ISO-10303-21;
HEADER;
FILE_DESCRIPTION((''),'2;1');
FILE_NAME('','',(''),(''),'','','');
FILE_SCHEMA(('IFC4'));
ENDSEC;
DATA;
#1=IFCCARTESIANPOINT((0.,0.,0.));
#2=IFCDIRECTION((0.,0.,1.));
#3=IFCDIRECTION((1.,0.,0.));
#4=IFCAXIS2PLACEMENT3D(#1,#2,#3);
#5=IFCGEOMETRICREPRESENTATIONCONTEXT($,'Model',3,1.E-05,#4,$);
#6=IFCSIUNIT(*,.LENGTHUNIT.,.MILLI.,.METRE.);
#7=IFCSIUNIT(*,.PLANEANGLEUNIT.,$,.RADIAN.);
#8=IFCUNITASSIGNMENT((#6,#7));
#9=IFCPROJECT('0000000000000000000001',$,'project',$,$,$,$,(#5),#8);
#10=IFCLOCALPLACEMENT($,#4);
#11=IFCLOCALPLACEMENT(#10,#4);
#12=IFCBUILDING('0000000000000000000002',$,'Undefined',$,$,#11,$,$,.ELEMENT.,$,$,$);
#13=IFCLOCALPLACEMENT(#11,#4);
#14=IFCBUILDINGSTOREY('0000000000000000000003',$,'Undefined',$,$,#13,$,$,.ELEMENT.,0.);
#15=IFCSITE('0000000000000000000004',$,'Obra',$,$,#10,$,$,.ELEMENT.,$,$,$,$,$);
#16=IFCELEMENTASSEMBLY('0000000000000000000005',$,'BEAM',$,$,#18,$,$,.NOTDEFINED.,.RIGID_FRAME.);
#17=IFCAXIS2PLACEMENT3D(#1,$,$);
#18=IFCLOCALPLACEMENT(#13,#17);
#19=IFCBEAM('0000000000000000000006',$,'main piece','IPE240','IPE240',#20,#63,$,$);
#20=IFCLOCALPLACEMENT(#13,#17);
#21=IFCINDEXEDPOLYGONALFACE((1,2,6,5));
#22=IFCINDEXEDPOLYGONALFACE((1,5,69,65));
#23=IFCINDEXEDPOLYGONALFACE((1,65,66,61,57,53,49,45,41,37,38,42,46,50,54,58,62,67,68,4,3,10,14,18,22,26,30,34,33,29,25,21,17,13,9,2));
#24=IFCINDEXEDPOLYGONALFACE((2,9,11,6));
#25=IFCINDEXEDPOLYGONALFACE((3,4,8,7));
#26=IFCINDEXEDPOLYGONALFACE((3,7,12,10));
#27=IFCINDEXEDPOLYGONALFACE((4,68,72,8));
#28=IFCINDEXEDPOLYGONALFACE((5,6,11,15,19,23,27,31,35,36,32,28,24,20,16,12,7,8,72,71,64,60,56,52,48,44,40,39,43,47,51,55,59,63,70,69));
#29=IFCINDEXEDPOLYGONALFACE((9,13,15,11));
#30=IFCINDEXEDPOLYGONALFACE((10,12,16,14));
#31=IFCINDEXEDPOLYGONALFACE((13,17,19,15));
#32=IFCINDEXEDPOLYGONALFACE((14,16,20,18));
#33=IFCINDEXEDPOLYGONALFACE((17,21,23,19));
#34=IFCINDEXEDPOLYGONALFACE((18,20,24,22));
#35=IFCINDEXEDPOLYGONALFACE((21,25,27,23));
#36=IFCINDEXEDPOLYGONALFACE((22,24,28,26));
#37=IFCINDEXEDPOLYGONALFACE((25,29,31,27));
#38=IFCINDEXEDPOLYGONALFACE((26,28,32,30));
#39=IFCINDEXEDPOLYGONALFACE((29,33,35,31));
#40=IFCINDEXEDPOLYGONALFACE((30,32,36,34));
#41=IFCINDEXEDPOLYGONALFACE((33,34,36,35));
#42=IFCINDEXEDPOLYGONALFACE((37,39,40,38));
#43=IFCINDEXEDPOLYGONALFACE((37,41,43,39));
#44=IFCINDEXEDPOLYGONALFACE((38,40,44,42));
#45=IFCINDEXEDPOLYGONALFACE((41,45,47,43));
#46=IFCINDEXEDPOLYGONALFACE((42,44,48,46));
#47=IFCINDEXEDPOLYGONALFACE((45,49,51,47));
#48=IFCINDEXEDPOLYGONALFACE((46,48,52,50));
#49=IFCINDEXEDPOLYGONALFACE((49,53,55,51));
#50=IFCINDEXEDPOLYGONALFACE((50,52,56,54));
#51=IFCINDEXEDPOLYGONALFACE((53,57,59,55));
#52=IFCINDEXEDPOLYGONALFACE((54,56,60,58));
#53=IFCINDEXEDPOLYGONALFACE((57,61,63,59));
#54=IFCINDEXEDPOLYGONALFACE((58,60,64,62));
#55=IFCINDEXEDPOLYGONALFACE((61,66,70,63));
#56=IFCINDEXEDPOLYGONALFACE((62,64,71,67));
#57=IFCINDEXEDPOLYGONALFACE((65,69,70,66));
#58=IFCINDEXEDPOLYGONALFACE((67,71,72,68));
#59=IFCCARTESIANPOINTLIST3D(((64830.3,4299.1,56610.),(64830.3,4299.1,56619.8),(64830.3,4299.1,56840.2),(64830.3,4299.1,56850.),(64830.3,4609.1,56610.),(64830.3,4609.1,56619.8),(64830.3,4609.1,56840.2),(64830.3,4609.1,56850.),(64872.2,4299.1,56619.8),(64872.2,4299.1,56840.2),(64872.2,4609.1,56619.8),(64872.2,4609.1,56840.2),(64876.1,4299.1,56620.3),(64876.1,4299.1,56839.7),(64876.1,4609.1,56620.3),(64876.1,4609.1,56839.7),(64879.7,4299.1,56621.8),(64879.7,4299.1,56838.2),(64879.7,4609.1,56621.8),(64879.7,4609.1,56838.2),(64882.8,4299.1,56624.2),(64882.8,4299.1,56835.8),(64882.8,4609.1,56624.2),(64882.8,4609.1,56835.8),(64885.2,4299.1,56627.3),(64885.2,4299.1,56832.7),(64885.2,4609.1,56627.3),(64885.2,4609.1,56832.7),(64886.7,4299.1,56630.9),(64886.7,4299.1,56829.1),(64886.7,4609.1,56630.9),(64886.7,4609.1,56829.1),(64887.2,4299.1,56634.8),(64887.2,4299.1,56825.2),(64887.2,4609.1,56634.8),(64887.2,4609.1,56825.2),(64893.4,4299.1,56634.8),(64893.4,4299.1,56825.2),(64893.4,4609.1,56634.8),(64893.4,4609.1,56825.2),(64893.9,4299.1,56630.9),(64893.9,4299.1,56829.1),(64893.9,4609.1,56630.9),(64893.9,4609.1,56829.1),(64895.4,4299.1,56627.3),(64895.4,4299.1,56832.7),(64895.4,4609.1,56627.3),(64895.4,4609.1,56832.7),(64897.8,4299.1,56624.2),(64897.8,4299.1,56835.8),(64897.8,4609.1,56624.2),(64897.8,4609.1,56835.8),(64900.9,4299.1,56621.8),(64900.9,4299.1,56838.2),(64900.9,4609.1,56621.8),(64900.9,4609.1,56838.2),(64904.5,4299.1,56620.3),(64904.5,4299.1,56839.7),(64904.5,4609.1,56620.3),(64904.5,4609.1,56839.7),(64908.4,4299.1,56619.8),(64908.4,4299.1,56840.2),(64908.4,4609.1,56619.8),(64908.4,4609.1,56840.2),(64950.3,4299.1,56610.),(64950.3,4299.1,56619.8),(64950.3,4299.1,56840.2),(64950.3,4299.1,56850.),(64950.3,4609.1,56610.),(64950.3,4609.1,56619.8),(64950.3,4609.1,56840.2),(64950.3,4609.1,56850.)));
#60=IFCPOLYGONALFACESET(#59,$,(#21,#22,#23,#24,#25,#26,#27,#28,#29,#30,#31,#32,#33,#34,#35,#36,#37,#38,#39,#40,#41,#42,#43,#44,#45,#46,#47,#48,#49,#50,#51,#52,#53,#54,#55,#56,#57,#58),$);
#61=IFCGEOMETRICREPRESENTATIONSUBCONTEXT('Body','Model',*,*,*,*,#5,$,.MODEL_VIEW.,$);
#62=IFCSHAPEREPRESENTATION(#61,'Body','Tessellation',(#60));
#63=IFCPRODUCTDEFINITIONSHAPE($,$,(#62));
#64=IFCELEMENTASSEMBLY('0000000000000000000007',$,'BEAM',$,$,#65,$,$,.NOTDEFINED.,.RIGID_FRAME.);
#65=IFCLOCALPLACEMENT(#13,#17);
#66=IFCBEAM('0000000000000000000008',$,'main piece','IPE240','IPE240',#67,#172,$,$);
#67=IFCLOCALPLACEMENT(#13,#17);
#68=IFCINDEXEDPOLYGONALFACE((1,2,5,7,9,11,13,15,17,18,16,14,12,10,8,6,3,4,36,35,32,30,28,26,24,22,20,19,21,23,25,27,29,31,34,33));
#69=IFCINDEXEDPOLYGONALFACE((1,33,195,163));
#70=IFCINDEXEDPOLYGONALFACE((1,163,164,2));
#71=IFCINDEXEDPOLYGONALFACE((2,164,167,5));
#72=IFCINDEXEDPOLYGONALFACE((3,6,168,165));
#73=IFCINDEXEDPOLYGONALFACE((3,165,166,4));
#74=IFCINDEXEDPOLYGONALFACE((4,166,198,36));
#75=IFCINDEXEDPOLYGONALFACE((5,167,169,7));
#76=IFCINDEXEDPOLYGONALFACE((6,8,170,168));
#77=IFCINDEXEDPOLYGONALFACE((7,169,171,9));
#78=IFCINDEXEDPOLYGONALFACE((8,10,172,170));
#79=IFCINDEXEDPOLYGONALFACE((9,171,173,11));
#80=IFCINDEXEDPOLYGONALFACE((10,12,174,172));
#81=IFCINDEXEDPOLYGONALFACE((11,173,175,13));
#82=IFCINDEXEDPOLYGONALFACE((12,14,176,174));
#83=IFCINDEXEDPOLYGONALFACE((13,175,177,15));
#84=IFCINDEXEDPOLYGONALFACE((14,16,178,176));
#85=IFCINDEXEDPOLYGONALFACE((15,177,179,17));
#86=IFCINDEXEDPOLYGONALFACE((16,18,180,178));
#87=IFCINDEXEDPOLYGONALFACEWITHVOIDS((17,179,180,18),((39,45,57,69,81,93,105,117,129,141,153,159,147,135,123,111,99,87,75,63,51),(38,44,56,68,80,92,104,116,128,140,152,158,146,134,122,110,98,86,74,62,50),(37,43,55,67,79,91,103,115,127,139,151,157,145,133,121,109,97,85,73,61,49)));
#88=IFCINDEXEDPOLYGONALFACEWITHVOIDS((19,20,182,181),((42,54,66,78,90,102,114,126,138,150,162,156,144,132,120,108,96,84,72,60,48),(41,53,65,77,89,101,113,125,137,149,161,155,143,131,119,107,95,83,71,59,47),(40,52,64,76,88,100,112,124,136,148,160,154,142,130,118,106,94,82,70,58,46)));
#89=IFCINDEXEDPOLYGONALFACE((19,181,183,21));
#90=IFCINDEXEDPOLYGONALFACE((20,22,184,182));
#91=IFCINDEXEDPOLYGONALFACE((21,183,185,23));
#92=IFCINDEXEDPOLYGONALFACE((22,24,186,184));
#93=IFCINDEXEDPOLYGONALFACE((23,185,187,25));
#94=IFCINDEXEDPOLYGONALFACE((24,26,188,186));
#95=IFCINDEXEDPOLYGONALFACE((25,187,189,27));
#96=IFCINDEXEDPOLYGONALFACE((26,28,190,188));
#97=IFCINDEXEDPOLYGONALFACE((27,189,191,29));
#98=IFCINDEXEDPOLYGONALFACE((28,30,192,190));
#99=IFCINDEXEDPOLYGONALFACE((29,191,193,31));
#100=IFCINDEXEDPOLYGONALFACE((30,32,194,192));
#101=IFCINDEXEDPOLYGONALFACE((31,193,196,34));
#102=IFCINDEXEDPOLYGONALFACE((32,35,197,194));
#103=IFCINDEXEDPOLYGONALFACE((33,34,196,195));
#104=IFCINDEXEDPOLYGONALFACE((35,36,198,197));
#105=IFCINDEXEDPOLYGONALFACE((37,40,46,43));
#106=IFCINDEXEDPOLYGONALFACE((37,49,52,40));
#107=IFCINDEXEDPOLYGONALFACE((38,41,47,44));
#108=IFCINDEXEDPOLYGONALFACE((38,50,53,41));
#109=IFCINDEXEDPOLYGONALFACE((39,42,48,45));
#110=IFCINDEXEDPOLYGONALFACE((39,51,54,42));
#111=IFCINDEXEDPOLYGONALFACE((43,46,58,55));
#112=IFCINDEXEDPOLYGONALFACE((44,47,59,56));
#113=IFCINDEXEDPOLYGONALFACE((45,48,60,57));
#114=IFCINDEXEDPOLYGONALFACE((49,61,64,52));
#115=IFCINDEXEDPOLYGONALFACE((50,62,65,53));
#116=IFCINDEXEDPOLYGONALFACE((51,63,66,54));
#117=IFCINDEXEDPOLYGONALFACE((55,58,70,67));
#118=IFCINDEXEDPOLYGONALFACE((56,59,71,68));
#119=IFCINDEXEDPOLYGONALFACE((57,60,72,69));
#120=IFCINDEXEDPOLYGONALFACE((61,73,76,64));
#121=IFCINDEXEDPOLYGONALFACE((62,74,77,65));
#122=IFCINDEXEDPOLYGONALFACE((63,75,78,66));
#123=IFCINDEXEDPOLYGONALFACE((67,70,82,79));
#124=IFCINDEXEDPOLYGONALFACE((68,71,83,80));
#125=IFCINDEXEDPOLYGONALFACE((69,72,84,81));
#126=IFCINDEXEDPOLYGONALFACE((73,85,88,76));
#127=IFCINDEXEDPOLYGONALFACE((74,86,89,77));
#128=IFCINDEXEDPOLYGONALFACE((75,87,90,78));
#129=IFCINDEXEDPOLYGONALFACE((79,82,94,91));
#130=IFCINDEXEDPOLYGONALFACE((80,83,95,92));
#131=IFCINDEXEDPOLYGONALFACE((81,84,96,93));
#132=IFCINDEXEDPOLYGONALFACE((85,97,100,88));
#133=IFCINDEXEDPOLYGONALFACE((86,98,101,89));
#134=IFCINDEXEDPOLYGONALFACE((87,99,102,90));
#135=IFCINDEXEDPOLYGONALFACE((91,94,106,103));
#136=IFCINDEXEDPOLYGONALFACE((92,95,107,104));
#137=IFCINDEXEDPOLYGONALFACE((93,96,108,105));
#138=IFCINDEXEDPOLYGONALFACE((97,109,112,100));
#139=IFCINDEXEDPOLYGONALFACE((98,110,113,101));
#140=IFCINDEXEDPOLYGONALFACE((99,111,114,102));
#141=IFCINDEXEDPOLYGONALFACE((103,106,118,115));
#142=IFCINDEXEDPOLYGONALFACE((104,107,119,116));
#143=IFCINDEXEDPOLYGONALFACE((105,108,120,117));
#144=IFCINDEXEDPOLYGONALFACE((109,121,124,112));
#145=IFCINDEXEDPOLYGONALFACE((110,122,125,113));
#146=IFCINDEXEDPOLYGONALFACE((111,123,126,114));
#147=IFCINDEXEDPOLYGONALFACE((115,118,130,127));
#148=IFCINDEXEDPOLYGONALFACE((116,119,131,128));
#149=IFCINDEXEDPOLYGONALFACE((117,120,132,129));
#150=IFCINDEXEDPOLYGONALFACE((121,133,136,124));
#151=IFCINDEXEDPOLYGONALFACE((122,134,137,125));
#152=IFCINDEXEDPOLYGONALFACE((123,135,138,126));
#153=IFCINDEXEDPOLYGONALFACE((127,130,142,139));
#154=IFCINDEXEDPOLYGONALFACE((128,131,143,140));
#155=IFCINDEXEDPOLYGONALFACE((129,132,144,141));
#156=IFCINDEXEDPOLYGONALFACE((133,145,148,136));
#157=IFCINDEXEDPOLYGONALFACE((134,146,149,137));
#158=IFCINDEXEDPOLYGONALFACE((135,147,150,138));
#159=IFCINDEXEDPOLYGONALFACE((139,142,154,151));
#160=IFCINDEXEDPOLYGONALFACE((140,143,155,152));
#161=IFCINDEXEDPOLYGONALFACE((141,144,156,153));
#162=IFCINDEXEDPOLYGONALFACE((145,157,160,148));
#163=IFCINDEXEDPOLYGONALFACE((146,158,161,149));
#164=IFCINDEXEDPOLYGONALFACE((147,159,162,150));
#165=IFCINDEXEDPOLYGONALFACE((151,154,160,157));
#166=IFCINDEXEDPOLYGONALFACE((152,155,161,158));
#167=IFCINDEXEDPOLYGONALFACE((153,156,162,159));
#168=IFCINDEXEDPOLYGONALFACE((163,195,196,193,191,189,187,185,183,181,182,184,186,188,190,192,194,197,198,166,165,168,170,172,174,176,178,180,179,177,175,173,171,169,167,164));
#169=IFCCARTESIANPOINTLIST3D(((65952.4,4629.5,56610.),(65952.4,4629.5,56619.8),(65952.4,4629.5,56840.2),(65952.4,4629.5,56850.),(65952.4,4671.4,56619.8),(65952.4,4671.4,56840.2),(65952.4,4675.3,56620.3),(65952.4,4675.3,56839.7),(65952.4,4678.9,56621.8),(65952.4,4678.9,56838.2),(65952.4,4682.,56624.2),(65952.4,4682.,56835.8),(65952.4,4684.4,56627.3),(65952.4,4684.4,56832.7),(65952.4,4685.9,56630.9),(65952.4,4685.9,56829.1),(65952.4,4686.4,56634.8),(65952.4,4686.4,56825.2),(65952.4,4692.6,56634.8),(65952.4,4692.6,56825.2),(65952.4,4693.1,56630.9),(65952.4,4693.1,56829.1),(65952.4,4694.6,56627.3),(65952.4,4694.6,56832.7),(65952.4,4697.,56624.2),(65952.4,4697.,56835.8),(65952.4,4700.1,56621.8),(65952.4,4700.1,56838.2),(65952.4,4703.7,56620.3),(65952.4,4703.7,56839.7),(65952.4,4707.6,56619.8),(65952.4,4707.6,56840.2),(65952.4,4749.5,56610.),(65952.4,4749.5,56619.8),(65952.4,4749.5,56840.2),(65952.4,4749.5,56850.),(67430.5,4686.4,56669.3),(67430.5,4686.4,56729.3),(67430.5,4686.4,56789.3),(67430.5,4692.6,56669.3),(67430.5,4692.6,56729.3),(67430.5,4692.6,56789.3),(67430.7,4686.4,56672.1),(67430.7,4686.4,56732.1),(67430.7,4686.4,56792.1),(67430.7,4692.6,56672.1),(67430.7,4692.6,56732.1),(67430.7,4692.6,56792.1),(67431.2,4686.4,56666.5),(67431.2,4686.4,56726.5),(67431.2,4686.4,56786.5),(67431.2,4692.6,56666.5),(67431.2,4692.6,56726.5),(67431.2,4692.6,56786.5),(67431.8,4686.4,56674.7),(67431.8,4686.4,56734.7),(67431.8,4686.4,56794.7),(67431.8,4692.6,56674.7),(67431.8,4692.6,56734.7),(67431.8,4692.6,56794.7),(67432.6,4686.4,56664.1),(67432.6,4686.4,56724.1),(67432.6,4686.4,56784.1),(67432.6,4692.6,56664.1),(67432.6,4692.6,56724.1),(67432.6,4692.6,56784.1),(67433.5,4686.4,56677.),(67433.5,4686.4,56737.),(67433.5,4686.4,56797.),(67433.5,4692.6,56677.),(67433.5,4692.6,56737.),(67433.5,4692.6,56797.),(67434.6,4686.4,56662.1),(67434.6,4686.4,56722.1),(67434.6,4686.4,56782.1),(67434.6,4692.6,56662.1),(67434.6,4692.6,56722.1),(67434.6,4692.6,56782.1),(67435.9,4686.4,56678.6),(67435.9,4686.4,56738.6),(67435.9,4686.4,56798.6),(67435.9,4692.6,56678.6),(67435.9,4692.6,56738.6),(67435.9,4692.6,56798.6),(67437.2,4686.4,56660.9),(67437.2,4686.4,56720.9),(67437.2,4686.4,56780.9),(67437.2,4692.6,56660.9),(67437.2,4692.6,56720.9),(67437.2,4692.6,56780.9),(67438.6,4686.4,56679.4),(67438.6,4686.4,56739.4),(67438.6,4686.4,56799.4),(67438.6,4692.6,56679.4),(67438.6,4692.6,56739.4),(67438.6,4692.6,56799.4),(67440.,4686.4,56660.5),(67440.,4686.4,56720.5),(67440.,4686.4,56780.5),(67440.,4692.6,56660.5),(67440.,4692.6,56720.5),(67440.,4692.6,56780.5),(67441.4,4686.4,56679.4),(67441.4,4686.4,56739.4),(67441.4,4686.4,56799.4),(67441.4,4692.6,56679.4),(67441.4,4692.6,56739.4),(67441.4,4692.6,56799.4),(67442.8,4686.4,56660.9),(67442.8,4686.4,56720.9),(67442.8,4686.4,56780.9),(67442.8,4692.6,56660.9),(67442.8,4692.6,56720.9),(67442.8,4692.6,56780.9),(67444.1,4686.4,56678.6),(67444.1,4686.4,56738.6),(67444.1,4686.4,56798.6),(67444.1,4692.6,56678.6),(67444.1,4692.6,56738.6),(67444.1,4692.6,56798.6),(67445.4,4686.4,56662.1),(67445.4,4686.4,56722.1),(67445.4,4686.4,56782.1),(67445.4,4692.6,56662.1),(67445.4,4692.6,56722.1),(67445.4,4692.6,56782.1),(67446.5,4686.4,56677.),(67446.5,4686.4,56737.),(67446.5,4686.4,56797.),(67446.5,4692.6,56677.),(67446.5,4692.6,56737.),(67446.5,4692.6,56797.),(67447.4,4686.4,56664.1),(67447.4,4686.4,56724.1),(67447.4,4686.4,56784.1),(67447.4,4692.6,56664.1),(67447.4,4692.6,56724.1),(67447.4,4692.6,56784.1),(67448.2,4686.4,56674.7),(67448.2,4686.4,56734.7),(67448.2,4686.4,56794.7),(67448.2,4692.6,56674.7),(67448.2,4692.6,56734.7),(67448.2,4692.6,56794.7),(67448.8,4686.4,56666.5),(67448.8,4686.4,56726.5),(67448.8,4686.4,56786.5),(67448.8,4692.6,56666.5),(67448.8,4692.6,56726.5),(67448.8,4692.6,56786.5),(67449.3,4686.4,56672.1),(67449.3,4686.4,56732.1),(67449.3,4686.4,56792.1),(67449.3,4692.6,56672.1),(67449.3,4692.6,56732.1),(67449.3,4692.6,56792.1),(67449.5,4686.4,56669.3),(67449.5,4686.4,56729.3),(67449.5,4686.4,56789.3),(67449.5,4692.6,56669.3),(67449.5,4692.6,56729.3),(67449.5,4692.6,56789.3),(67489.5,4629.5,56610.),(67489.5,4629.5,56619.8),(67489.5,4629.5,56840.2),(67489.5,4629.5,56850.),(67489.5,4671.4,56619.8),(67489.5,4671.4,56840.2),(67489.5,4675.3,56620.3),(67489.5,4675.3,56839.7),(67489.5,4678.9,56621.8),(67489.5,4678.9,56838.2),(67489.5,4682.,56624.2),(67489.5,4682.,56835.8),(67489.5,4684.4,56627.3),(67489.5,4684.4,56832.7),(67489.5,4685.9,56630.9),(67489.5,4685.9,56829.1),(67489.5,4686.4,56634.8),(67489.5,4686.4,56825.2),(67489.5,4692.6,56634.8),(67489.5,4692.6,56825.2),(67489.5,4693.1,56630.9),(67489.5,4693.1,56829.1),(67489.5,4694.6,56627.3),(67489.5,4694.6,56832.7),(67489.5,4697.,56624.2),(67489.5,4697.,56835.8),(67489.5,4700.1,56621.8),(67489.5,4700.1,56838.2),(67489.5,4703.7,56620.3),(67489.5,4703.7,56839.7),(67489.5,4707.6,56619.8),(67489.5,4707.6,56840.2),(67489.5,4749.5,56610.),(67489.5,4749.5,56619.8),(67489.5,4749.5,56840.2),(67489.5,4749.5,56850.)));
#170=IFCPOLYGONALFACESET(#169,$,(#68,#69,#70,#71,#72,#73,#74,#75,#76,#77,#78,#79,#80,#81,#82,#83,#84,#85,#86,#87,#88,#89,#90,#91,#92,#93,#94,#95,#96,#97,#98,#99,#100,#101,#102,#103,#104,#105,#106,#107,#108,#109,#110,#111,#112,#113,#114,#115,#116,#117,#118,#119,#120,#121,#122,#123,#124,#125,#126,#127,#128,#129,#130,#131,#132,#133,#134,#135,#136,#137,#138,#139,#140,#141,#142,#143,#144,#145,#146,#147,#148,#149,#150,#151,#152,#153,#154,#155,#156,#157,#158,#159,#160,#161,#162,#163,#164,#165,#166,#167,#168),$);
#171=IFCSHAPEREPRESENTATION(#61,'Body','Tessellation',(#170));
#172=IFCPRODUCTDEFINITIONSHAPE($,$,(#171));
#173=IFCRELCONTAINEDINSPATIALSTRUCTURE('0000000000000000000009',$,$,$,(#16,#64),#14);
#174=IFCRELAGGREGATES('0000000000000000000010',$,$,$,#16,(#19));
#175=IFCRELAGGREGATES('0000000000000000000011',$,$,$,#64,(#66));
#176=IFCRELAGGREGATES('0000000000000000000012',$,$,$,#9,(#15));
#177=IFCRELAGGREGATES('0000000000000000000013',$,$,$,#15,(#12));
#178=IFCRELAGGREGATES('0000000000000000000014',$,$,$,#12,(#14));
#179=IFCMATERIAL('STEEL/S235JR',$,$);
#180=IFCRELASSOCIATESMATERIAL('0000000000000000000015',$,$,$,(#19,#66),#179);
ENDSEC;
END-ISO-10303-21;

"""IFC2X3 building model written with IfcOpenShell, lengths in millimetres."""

from ifc_helpers import new_model, si_unit, frame, origin_with_axes, origin_2d_with_axis, place, context, subcontext, project, spatial, circle, i_section, extrude, clip, halfspace, source, transform, mapped, material, element, aggregate, save


model = new_model("IFC2X3")

# Units and contexts
model_context = context("Model", 3, precision=1e-05, world=origin_with_axes())
body_context = subcontext(model_context, "Body", "Model", "MODEL_VIEW")
ifc_project = project(units=[si_unit("LENGTHUNIT", "METRE", prefix="MILLI"), si_unit("PLANEANGLEUNIT", "RADIAN")], contexts=[model_context])

# Site, building, storey
site_placement = place(None, origin_with_axes())
site = spatial("IfcSite", under=ifc_project, at=site_placement, Name="Obra", CompositionType="ELEMENT")
building_placement = place(site_placement, origin_with_axes())
building = spatial("IfcBuilding", under=site, at=building_placement, Name="Undefined", CompositionType="ELEMENT")
storey_placement = place(building_placement, origin_with_axes())
storey = spatial("IfcBuildingStorey", under=building, at=storey_placement, Name="Undefined", CompositionType="ELEMENT", Elevation=0.0)

# Shared definitions
ifc_material_1 = material(Name="STEEL/S235JR")

# Element assembly, beam
assembly_1_placement = place(storey_placement, origin_with_axes())
assembly_1 = element("IfcElementAssembly", 1, at=assembly_1_placement, inside=storey, Name="BEAM", AssemblyPlace="NOTDEFINED", PredefinedType="RIGID_FRAME")
beam_1_placement = place(assembly_1_placement, frame((64890.3, 4299.1, 56730.0), z_axis=(0.0, 0.0, 1.0), x_axis=(0.0, 1.0, 0.0)))
beam_1 = element("IfcBeam", 2, at=beam_1_placement, material=ifc_material_1, Name="main piece", Description="IPE240", ObjectType="IPE240", context=body_context, shape_type="SweptSolid", body=[
    extrude(i_section(OverallWidth=120.0, OverallDepth=240.0, WebThickness=6.2, FlangeThickness=9.8, FilletRadius=15.0, at=origin_2d_with_axis()), frame((310.0, 0.0, 0.0), z_axis=(-1.0, 0.0, 0.0), x_axis=(0.0, -1.0, 0.0)), (0.0, 0.0, 1.0), 310.0),
])
aggregate(assembly_1, [beam_1])

# Element assembly, beam, opening
assembly_2_placement = place(storey_placement, origin_with_axes())
assembly_2 = element("IfcElementAssembly", 3, at=assembly_2_placement, inside=storey, Name="BEAM", AssemblyPlace="NOTDEFINED", PredefinedType="RIGID_FRAME")
beam_2_placement = place(assembly_2_placement, frame((65952.4, 4689.5, 56730.0), z_axis=(0.0, 0.0, 1.0), x_axis=(1.0, 0.0, 0.0)))
beam_2 = element("IfcBeam", 4, at=beam_2_placement, material=ifc_material_1, Name="main piece", Description="IPE240", ObjectType="IPE240", context=body_context, shape_type="Clipping", body=[
    clip(extrude(i_section(OverallWidth=120.0, OverallDepth=240.0, WebThickness=6.2, FlangeThickness=9.8, FilletRadius=15.0, at=origin_2d_with_axis()), frame((1754.5, 0.0, 0.0), z_axis=(-1.0, 0.0, 0.0), x_axis=(0.0, -1.0, 0.0)), (0.0, 0.0, 1.0), 1754.5), halfspace(frame((1537.1, -60.0, -120.0), z_axis=(1.0, 0.000019, 0.0), x_axis=(0.0, 0.0, 1.0)), False)),
])
shared_shape_1 = source(origin_with_axes(), body_context, "Body", "SweptSolid", [
    extrude(circle(Radius=9.5, at=origin_2d_with_axis()), frame((0.0, -3.2, 0.0), z_axis=(0.0, 1.0, 0.0), x_axis=(1.0, 0.0, 0.0)), (0.0, 0.0, 1.0), 6.4),
])
opening_1_placement = place(assembly_2_placement, frame((67490.0, 4689.5, 56850.0), z_axis=(-1.0, 0.0, 0.0), x_axis=(0.0, 0.0, -1.0)))
element("IfcOpeningElement", 5, at=opening_1_placement, cuts=beam_2, ObjectType="Opening", context=body_context, shape_type="MappedRepresentation", body=[
    mapped(shared_shape_1, transform((60.0, 0.0, 50.0))),
    mapped(shared_shape_1, transform((120.0, 0.0, 50.0))),
    mapped(shared_shape_1, transform((180.0, 0.0, 50.0))),
])
aggregate(assembly_2, [beam_2])

save(model, "model.ifc")
